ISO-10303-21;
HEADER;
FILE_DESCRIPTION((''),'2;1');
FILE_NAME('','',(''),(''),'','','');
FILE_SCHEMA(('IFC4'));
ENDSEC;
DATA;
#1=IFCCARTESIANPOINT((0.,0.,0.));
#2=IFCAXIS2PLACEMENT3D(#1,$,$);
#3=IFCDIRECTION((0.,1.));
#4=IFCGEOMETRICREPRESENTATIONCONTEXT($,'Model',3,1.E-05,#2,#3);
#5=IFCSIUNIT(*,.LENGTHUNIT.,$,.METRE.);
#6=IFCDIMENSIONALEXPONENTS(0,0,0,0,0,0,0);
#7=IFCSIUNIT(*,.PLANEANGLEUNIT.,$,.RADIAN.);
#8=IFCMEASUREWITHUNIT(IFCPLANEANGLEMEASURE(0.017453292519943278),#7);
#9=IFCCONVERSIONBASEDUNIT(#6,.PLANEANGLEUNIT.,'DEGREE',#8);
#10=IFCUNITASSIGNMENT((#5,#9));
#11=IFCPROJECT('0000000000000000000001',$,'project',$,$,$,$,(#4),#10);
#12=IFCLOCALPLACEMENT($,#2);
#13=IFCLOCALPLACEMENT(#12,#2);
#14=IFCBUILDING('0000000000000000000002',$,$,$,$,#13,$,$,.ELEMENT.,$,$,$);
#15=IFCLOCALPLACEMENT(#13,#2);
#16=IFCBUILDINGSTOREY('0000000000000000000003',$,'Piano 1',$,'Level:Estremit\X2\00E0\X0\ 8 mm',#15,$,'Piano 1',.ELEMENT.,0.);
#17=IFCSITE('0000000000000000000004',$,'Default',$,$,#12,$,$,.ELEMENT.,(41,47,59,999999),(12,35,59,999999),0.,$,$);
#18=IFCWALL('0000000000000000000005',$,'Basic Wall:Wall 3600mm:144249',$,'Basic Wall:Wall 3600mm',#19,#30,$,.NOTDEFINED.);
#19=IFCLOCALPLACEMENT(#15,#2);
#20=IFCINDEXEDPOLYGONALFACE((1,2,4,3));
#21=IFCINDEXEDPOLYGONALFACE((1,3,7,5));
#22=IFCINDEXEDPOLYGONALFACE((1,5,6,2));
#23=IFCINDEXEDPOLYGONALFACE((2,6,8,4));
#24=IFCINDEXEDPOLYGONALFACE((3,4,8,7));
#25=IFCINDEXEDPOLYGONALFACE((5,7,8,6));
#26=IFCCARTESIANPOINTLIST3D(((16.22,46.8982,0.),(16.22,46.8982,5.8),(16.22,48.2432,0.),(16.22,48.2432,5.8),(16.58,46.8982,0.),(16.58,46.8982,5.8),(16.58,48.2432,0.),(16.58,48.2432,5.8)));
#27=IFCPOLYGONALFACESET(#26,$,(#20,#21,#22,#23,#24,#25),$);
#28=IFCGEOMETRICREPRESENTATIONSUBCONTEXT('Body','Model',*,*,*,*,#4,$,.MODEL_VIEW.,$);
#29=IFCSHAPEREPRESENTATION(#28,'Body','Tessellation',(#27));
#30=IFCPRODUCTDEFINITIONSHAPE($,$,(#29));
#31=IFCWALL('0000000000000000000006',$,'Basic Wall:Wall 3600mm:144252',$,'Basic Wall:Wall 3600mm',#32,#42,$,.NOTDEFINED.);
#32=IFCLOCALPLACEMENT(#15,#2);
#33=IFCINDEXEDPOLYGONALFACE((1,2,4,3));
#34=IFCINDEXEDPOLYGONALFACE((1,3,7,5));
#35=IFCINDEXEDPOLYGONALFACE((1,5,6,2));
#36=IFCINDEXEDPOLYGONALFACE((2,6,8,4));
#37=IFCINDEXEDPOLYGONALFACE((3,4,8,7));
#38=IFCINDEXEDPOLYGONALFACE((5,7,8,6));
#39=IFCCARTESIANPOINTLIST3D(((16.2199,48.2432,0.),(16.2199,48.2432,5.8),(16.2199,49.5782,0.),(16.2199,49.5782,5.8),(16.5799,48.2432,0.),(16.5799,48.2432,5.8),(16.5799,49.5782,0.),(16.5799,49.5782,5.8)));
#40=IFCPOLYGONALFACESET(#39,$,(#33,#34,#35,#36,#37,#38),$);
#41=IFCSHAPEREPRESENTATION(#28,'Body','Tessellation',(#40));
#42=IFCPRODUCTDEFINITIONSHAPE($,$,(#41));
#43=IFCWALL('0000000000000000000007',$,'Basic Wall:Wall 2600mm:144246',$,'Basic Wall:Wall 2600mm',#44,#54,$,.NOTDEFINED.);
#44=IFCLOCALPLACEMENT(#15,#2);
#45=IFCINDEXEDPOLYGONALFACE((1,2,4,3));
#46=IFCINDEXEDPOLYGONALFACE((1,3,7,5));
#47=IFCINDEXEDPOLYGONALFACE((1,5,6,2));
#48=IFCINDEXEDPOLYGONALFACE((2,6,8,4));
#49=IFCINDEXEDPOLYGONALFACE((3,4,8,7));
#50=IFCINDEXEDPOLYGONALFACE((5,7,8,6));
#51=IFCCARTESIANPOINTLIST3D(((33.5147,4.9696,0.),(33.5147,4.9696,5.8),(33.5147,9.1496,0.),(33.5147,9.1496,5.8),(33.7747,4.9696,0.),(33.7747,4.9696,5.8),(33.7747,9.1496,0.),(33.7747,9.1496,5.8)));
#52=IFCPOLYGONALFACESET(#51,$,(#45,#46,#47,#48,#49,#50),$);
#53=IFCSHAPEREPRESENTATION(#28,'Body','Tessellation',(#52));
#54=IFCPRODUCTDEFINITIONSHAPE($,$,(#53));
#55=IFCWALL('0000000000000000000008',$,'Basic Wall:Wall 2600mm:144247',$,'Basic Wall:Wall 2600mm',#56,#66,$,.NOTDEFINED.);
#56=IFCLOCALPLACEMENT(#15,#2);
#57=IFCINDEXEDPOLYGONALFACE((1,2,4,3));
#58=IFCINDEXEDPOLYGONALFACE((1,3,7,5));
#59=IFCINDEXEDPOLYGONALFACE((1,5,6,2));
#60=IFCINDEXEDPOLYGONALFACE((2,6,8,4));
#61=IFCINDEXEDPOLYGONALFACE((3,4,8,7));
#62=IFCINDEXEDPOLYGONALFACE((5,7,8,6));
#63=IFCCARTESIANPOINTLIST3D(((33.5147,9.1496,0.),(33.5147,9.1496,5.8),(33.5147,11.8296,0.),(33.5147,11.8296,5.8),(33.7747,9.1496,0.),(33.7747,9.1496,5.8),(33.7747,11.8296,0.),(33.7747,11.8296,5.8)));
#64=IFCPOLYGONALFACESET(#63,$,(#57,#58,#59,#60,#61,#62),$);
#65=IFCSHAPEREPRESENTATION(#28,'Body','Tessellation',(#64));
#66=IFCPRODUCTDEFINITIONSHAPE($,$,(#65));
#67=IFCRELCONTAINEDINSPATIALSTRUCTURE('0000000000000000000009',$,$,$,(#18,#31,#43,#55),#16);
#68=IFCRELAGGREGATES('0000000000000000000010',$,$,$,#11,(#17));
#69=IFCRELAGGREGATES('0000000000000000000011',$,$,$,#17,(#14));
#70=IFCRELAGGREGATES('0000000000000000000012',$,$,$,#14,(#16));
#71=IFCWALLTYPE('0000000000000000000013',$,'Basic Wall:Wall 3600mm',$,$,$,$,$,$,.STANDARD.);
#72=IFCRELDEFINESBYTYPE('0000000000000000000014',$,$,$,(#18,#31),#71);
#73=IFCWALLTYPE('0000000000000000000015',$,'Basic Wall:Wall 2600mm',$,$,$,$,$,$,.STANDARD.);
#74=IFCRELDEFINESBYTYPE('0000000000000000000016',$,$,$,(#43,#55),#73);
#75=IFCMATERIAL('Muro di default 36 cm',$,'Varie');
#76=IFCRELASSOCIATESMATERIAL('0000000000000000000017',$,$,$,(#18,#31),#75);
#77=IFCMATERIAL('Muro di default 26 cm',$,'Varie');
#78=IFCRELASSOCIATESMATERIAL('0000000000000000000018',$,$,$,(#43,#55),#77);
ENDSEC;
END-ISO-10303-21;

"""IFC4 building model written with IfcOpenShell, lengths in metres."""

from ifc_helpers import new_model, entity, si_unit, converted_unit, direction, frame, origin, place, context, subcontext, project, spatial, indexed_curve, outline, extrude, material, type_object, element, save


model = new_model("IFC4")

# Units and contexts
model_context = context("Model", 3, precision=1e-05, world=origin(), true_north=direction((0.0, 1.0)))
body_context = subcontext(model_context, "Body", "Model", "MODEL_VIEW")
ifc_project = project(units=[si_unit("LENGTHUNIT", "METRE"), converted_unit("PLANEANGLEUNIT", "DEGREE", entity("IfcPlaneAngleMeasure", 0.017453292519943278), si_unit("PLANEANGLEUNIT", "RADIAN"), dimensions=[0, 0, 0, 0, 0, 0, 0])], contexts=[model_context])

# Site, building, storey
site_placement = place(None, origin())
site = spatial("IfcSite", under=ifc_project, at=site_placement, Name="Default", CompositionType="ELEMENT", RefLatitude=(41, 47, 59, 999999), RefLongitude=(12, 35, 59, 999999), RefElevation=0.0)
building_placement = place(site_placement, origin())
building = spatial("IfcBuilding", under=site, at=building_placement, CompositionType="ELEMENT")
storey_placement = place(building_placement, origin())
storey = spatial("IfcBuildingStorey", under=building, at=storey_placement, Name="Piano 1", ObjectType="Level:Estremità 8 mm", LongName="Piano 1", CompositionType="ELEMENT", Elevation=0.0)

# Walls
ifc_material_1 = material(Name="Muro di default 36 cm", Category="Varie")
wall_type_1 = type_object("IfcWallType", Name="Basic Wall:Wall 3600mm", PredefinedType="STANDARD")
wall_1_placement = place(storey_placement, frame((16.4, 46.8982, 0.0), z_axis=(0.0, 0.0, 1.0), x_axis=(0.0, 1.0, 0.0)))
element("IfcWall", 1, at=wall_1_placement, inside=storey, type_object=wall_type_1, material=ifc_material_1, Name="Basic Wall:Wall 3600mm:144249", ObjectType="Basic Wall:Wall 3600mm", PredefinedType="NOTDEFINED", context=body_context, shape_type="SweptSolid", body=[
    extrude(outline(indexed_curve([(1.345, 0.18), (0.0, 0.18), (0.0, -0.18), (1.345, -0.18), (1.345, 0.18)], self_intersect=False)), origin(), (0.0, 0.0, 1.0), 5.8),
])
wall_2_placement = place(storey_placement, frame((16.3999, 48.2432, 0.0), z_axis=(0.0, 0.0, 1.0), x_axis=(0.0, 1.0, 0.0)))
element("IfcWall", 2, at=wall_2_placement, inside=storey, type_object=wall_type_1, material=ifc_material_1, Name="Basic Wall:Wall 3600mm:144252", ObjectType="Basic Wall:Wall 3600mm", PredefinedType="NOTDEFINED", context=body_context, shape_type="SweptSolid", body=[
    extrude(outline(indexed_curve([(1.335, 0.18), (0.0, 0.18), (0.0, -0.18), (1.335, -0.18), (1.335, 0.18)], self_intersect=False)), origin(), (0.0, 0.0, 1.0), 5.8),
])
ifc_material_2 = material(Name="Muro di default 26 cm", Category="Varie")
wall_type_2 = type_object("IfcWallType", Name="Basic Wall:Wall 2600mm", PredefinedType="STANDARD")
wall_3_placement = place(storey_placement, frame((33.6447, 4.9696, 0.0), z_axis=(0.0, 0.0, 1.0), x_axis=(0.0, 1.0, 0.0)))
element("IfcWall", 3, at=wall_3_placement, inside=storey, type_object=wall_type_2, material=ifc_material_2, Name="Basic Wall:Wall 2600mm:144246", ObjectType="Basic Wall:Wall 2600mm", PredefinedType="NOTDEFINED", context=body_context, shape_type="SweptSolid", body=[
    extrude(outline(indexed_curve([(4.18, 0.13), (0.0, 0.13), (0.0, -0.13), (4.18, -0.13), (4.18, 0.13)], self_intersect=False)), origin(), (0.0, 0.0, 1.0), 5.8),
])
wall_4_placement = place(storey_placement, frame((33.6447, 9.1496, 0.0), z_axis=(0.0, 0.0, 1.0), x_axis=(0.0, 1.0, 0.0)))
element("IfcWall", 4, at=wall_4_placement, inside=storey, type_object=wall_type_2, material=ifc_material_2, Name="Basic Wall:Wall 2600mm:144247", ObjectType="Basic Wall:Wall 2600mm", PredefinedType="NOTDEFINED", context=body_context, shape_type="SweptSolid", body=[
    extrude(outline(indexed_curve([(2.68, 0.13), (0.0, 0.13), (0.0, -0.13), (2.68, -0.13), (2.68, 0.13)], self_intersect=False)), origin(), (0.0, 0.0, 1.0), 5.8),
])

save(model, "model.ifc")
